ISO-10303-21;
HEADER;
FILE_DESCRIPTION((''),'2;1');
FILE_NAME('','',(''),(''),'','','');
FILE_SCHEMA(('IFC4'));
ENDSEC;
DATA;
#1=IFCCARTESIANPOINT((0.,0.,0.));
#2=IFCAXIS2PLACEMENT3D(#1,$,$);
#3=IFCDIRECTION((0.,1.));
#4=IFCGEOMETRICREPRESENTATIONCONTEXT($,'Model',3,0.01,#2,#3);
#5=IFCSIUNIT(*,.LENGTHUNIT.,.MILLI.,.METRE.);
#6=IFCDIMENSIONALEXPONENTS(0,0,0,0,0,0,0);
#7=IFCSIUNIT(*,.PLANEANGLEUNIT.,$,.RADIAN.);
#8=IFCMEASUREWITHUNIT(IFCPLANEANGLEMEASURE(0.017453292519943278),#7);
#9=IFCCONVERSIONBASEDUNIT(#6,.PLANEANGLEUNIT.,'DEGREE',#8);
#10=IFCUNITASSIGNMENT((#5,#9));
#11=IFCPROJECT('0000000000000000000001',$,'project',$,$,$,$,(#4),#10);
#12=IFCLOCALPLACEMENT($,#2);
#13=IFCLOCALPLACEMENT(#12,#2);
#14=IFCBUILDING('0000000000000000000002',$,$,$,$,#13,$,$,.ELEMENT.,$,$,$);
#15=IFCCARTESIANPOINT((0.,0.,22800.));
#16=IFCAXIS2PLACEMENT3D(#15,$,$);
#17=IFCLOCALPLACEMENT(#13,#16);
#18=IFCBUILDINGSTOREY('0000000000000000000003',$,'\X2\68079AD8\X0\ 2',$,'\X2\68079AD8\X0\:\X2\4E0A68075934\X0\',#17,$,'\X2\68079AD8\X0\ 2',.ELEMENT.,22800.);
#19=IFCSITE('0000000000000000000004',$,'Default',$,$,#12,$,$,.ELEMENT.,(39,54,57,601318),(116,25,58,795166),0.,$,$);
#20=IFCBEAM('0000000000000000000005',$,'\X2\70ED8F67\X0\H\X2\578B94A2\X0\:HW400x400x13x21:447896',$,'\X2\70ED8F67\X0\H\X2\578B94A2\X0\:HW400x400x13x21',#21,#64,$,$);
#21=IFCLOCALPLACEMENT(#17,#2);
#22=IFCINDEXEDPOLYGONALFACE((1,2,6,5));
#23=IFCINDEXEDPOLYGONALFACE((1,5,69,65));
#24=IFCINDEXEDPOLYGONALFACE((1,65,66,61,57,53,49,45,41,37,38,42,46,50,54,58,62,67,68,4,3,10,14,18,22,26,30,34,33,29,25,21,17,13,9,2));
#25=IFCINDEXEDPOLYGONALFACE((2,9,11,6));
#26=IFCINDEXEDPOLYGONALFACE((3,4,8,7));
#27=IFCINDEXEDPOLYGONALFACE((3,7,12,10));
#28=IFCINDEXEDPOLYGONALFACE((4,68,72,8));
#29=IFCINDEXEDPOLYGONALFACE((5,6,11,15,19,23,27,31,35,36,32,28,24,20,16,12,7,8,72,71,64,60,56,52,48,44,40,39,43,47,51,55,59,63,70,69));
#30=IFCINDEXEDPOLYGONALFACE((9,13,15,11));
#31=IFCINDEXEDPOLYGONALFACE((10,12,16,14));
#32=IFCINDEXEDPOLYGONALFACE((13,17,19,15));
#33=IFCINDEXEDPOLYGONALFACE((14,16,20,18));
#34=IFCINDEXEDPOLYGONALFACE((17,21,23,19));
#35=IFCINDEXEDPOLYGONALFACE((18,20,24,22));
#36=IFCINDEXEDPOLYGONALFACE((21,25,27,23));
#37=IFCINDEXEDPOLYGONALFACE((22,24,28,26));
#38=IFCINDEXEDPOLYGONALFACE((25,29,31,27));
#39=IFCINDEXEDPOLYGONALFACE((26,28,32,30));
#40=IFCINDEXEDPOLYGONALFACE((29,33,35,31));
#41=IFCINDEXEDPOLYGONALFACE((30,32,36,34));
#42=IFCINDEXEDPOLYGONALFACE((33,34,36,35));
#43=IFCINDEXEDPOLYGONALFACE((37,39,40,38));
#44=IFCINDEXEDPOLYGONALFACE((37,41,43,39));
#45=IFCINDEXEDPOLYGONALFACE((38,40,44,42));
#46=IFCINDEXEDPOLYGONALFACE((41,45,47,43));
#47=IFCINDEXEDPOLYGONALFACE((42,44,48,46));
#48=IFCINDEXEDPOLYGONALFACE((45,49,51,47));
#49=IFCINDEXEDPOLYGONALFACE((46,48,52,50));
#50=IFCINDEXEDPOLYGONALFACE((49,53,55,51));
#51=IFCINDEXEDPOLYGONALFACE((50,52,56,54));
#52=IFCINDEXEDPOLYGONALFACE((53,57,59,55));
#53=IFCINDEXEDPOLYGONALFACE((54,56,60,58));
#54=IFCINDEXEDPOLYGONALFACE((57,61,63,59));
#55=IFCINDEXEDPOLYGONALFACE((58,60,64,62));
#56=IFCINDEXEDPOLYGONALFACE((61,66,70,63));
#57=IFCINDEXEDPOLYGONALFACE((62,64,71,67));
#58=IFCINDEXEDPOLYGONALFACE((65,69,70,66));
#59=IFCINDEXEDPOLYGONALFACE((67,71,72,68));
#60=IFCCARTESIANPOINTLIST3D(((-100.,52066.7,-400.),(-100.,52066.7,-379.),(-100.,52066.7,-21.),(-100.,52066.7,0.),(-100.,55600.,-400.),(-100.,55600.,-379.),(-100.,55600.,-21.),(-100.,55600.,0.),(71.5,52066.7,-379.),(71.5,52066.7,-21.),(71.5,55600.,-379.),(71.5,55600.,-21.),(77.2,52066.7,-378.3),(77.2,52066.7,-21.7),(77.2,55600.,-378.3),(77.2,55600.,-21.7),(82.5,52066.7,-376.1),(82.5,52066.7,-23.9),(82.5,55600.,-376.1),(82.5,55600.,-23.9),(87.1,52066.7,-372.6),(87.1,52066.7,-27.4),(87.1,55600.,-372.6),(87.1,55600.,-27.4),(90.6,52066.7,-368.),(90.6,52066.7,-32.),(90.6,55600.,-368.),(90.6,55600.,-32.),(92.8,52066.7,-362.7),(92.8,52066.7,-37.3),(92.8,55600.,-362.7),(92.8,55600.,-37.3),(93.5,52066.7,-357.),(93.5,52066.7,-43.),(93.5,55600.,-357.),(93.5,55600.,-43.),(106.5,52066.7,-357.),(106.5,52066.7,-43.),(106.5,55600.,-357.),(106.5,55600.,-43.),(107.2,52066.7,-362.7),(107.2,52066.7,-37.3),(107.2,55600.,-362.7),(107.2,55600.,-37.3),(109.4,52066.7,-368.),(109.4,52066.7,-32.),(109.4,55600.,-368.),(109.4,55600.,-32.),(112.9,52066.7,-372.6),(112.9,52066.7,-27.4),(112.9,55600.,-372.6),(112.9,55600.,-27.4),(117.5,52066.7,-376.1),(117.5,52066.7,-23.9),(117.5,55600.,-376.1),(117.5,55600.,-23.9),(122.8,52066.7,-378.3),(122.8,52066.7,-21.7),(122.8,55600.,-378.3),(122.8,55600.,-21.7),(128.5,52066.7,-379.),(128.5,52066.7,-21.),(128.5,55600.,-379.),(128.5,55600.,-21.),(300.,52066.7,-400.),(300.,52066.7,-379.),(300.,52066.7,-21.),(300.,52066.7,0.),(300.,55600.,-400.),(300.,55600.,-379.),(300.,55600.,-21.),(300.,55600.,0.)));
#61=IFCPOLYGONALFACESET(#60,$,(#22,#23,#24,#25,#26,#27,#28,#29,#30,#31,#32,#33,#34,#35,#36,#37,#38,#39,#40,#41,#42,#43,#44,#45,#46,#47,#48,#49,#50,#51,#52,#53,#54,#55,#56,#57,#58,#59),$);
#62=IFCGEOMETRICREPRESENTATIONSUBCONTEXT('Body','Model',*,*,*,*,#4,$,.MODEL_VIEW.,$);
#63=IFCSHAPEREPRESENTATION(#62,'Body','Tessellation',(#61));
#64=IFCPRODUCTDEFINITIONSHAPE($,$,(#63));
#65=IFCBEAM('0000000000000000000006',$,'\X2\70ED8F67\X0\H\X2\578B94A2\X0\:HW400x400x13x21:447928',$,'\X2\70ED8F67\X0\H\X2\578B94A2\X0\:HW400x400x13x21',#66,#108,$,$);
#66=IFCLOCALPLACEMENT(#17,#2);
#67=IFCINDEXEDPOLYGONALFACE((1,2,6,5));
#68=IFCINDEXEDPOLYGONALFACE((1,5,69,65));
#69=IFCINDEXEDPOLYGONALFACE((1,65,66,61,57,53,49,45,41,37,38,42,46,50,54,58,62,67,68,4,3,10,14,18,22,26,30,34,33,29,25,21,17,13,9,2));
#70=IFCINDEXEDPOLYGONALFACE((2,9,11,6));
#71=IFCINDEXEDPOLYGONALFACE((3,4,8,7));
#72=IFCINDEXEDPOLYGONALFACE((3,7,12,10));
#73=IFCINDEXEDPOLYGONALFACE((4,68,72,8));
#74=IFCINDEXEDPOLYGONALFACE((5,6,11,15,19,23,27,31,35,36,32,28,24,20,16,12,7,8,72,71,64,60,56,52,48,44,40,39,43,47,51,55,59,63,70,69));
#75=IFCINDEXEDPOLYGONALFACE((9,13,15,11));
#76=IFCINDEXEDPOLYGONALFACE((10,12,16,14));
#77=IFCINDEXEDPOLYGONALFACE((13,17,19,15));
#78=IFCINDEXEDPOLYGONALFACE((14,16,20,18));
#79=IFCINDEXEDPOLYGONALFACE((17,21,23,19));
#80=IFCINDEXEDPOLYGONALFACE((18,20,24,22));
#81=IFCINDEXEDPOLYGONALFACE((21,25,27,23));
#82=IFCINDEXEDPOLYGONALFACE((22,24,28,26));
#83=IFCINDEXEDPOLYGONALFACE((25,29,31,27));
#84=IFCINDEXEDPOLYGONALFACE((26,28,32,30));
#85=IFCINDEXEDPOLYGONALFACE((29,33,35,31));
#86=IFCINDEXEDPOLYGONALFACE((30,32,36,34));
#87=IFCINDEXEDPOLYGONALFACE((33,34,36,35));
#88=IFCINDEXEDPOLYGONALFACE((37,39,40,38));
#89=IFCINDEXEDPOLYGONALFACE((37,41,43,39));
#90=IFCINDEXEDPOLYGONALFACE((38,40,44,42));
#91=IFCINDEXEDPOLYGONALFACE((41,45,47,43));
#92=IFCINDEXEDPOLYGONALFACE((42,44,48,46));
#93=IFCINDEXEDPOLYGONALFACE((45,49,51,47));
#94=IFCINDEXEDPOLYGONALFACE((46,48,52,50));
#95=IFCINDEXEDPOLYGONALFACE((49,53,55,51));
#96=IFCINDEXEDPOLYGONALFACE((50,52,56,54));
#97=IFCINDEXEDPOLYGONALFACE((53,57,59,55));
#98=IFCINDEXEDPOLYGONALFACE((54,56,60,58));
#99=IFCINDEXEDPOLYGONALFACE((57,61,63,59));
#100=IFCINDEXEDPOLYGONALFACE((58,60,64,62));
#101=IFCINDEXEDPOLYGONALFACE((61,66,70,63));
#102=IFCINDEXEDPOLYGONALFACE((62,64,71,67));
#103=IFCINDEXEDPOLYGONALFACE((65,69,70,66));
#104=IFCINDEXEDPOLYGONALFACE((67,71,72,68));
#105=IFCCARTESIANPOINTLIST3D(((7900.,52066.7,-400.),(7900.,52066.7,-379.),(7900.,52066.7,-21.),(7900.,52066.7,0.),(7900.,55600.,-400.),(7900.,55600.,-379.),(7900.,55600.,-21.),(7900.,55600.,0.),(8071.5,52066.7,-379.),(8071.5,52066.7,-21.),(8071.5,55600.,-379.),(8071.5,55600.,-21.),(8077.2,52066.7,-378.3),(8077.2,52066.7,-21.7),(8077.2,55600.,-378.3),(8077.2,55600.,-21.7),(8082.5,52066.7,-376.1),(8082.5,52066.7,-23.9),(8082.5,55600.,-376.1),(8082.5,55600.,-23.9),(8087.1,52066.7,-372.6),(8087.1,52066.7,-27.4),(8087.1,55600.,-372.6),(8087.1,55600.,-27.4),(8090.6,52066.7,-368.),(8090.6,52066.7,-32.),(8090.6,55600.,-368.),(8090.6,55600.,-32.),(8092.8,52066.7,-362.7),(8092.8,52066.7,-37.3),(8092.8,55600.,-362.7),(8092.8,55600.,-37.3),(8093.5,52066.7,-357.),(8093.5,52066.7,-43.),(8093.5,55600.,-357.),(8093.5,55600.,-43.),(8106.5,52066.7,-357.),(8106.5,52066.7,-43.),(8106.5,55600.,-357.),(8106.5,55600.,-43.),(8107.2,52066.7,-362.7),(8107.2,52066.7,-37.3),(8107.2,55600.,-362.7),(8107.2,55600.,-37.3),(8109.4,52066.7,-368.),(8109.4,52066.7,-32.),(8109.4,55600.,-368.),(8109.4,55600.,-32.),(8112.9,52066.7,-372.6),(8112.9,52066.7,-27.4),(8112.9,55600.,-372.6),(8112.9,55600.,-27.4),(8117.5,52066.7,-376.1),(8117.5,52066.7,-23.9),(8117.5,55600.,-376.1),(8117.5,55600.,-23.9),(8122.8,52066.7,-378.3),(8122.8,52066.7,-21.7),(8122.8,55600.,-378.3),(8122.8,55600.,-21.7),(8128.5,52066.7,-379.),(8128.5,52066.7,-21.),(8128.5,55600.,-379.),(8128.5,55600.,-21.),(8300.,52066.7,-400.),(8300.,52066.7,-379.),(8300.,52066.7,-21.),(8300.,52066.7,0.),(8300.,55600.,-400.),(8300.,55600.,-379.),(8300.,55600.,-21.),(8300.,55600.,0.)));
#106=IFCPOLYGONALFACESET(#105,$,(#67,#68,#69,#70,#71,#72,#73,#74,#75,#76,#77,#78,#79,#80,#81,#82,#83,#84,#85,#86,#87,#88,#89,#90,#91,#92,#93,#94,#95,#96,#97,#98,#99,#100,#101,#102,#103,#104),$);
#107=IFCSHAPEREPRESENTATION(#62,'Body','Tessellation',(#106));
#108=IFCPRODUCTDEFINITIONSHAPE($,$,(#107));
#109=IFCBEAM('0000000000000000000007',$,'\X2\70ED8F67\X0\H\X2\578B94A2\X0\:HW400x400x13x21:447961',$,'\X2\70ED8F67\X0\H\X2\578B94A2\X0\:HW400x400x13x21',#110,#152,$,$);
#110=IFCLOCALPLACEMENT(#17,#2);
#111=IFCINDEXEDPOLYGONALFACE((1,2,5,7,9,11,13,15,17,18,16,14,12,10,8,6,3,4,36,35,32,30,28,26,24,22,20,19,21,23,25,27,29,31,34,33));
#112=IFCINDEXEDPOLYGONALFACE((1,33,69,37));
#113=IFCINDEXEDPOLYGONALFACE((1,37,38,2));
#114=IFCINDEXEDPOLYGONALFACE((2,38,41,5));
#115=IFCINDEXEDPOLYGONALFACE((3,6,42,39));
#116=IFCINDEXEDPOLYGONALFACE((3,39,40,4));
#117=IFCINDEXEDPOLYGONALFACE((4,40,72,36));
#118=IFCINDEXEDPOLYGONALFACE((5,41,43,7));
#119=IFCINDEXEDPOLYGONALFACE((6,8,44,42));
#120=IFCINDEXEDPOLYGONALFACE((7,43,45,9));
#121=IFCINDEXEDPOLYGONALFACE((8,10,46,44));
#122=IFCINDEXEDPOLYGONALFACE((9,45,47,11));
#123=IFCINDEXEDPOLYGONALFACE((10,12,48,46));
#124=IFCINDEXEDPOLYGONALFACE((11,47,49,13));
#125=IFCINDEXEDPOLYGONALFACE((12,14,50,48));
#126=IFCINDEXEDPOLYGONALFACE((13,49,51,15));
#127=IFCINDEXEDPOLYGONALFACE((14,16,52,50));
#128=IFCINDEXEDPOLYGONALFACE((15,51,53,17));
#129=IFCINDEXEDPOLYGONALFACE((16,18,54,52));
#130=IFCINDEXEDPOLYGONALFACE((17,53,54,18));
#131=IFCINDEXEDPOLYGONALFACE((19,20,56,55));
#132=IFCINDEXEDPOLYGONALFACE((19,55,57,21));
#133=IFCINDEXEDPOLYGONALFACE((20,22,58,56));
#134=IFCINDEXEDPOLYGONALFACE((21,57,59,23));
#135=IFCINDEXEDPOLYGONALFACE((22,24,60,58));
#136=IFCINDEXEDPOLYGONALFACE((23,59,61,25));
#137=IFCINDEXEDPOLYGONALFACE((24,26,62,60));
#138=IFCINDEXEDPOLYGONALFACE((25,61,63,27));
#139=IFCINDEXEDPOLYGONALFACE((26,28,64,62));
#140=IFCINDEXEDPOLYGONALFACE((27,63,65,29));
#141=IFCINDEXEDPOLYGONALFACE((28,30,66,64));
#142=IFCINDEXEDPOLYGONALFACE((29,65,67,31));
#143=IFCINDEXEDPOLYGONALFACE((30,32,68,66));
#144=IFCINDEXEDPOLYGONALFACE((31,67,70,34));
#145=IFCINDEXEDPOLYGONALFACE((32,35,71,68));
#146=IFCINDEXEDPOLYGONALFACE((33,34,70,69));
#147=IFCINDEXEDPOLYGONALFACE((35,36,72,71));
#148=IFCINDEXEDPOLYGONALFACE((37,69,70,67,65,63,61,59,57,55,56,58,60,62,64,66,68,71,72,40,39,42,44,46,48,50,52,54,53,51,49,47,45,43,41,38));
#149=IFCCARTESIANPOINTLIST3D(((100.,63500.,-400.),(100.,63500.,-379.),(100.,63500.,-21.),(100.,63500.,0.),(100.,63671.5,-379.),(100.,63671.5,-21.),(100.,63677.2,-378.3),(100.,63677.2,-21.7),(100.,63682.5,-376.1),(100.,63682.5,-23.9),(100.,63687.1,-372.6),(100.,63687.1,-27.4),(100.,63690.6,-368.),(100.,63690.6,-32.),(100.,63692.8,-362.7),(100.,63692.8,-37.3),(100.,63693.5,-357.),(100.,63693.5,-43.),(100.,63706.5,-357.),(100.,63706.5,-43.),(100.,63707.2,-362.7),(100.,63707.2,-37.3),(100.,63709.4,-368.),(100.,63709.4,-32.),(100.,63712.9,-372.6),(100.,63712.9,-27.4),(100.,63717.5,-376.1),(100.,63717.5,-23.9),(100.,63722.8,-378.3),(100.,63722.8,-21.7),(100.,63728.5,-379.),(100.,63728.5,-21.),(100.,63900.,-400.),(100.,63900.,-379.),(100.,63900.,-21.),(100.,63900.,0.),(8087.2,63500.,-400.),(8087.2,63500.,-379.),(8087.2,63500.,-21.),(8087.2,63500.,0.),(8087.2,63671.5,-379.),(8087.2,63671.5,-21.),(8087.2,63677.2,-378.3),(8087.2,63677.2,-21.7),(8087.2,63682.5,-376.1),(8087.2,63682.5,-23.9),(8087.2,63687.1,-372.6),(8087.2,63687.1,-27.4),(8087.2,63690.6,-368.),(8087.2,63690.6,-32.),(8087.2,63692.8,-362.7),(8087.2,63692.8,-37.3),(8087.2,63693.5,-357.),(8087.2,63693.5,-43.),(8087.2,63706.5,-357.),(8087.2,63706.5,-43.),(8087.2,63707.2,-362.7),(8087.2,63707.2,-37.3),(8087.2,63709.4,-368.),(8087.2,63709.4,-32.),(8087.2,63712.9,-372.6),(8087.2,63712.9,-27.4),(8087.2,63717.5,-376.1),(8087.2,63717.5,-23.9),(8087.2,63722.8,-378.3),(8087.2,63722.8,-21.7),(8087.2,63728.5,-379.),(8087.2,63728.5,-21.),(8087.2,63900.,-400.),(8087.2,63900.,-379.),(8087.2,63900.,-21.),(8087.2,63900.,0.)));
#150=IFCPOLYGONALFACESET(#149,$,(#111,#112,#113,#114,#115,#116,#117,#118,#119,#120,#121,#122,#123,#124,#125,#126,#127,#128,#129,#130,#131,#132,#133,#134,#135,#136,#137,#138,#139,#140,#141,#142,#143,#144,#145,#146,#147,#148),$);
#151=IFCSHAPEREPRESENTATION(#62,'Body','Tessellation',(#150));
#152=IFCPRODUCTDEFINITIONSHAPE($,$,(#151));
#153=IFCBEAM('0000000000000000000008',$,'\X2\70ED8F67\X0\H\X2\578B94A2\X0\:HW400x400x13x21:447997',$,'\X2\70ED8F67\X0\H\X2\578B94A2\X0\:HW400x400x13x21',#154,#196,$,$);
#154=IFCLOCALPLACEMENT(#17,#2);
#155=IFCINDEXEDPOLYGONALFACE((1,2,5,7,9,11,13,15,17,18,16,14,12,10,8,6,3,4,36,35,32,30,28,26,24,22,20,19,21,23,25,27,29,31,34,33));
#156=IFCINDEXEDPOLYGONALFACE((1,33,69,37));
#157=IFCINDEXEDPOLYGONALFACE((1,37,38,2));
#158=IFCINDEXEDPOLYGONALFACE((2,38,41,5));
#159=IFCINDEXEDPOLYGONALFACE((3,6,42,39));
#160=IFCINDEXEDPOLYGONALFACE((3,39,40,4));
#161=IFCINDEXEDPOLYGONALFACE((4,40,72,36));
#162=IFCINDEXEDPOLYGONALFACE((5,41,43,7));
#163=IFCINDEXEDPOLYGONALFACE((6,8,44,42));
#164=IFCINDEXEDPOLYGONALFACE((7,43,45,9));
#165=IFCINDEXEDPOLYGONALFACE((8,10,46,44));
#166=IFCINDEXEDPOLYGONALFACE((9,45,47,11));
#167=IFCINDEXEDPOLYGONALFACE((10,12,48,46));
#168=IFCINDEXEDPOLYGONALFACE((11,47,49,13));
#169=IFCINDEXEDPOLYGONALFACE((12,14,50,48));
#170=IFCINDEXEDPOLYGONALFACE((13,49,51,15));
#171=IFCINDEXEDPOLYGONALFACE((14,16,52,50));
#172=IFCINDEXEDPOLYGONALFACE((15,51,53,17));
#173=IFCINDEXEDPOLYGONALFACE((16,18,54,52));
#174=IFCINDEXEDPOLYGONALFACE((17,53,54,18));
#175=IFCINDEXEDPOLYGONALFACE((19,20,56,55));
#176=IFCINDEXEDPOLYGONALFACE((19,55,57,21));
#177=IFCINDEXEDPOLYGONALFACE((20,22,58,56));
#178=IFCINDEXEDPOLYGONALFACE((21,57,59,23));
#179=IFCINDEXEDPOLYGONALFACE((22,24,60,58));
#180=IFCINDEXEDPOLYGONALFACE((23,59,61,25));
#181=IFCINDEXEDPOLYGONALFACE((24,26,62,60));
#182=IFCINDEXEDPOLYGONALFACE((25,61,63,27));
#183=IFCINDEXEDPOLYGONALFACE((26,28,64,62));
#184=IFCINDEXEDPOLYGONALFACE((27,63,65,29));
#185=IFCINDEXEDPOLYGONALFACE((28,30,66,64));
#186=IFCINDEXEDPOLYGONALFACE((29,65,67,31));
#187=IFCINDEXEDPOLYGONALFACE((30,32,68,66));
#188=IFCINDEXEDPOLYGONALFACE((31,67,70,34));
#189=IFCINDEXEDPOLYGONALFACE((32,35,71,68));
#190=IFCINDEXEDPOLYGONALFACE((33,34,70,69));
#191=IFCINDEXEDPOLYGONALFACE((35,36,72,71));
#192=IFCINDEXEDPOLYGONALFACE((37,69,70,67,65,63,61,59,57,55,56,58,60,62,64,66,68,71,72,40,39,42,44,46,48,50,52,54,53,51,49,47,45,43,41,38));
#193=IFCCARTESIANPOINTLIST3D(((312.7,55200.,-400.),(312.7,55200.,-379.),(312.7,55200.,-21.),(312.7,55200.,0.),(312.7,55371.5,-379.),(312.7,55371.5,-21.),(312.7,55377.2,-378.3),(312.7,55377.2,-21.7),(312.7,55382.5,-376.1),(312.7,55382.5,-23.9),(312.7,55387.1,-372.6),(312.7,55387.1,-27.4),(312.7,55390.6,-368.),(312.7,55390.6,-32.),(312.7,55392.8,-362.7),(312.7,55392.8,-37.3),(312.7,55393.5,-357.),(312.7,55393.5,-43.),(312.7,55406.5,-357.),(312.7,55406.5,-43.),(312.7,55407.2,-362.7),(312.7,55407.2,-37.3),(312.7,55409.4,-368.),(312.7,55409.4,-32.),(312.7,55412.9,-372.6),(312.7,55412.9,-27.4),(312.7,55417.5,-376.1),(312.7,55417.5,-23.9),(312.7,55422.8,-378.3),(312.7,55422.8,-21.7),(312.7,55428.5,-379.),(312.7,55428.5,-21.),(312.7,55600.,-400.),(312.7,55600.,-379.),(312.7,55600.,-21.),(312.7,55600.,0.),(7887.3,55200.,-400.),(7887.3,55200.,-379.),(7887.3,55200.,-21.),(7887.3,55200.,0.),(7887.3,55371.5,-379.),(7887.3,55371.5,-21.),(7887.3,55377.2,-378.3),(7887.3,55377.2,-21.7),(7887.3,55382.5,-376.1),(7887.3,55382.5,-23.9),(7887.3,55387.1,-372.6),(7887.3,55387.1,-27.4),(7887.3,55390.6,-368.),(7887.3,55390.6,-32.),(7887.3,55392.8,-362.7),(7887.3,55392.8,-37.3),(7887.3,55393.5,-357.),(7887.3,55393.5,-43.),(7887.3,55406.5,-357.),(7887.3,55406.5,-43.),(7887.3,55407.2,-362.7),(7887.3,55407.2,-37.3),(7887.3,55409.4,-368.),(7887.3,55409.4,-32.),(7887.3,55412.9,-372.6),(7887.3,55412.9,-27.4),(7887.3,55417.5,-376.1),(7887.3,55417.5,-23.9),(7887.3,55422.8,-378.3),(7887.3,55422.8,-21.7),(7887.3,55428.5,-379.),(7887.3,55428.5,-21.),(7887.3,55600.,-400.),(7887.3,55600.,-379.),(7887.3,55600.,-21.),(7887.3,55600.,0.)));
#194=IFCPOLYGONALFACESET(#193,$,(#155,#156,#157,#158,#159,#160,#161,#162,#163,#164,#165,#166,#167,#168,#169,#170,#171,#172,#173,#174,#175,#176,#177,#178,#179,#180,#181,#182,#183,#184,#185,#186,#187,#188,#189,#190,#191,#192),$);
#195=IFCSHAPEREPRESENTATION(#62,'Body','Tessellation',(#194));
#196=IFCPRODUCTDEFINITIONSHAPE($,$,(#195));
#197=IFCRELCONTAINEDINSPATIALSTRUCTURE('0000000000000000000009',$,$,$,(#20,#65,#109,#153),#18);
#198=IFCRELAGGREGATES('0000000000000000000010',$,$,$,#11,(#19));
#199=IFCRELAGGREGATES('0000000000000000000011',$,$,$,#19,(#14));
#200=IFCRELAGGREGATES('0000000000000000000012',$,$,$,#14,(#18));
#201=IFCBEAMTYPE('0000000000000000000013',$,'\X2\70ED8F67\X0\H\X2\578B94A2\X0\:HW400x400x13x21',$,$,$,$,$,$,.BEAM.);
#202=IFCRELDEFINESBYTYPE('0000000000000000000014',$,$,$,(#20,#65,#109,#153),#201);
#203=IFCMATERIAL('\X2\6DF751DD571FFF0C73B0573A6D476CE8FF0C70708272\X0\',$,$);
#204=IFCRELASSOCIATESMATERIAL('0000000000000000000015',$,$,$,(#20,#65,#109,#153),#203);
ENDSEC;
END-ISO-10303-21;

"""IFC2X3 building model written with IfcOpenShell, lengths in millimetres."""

from ifc_helpers import new_model, entity, si_unit, converted_unit, direction, frame, frame_2d, origin, place, context, subcontext, project, spatial, i_section, extrude, material, type_object, element, save


model = new_model("IFC2X3")

# Units and contexts
model_context = context("Model", 3, precision=0.01, world=origin(), true_north=direction((0.0, 1.0)))
body_context = subcontext(model_context, "Body", "Model", "MODEL_VIEW")
ifc_project = project(units=[si_unit("LENGTHUNIT", "METRE", prefix="MILLI"), converted_unit("PLANEANGLEUNIT", "DEGREE", entity("IfcPlaneAngleMeasure", 0.017453292519943278), si_unit("PLANEANGLEUNIT", "RADIAN"), dimensions=[0, 0, 0, 0, 0, 0, 0])], contexts=[model_context])

# Site, building, storey
site_placement = place(None, origin())
site = spatial("IfcSite", under=ifc_project, at=site_placement, Name="Default", CompositionType="ELEMENT", RefLatitude=(39, 54, 57, 601318), RefLongitude=(116, 25, 58, 795166), RefElevation=0.0)
building_placement = place(site_placement, origin())
building = spatial("IfcBuilding", under=site, at=building_placement, CompositionType="ELEMENT")
storey_placement = place(building_placement, frame((0.0, 0.0, 22800.0)))
storey = spatial("IfcBuildingStorey", under=building, at=storey_placement, Name="标高 2", ObjectType="标高:上标头", LongName="标高 2", CompositionType="ELEMENT", Elevation=22800.0)

# Beams
ifc_material = material(Name="混凝土，现场浇注，灰色")
beam_type = type_object("IfcBeamType", Name="热轧H型钢:HW400x400x13x21", PredefinedType="BEAM")
beam_1_placement = place(storey_placement, frame((100.0, 55400.0, 0.0), z_axis=(0.0, 0.0, 1.0), x_axis=(0.0, -1.0, 0.0)))
element("IfcBeam", 1, at=beam_1_placement, inside=storey, type_object=beam_type, material=ifc_material, Name="热轧H型钢:HW400x400x13x21:447896", ObjectType="热轧H型钢:HW400x400x13x21", context=body_context, shape_type="SweptSolid", body=[
    extrude(i_section(OverallWidth=400.0, OverallDepth=400.0, WebThickness=13.0, FlangeThickness=21.0, FilletRadius=22.0, at=frame_2d((0.0, 0.0), x_axis=(0.0, 1.0))), frame((-200.0, 0.0, -200.0), z_axis=(1.0, 0.0, 0.0), x_axis=(0.0, 0.0, -1.0)), (0.0, 0.0, 1.0), 3533.3),
])
beam_2_placement = place(storey_placement, frame((8100.0, 55400.0, 0.0), z_axis=(0.0, 0.0, 1.0), x_axis=(0.0, -1.0, 0.0)))
element("IfcBeam", 2, at=beam_2_placement, inside=storey, type_object=beam_type, material=ifc_material, Name="热轧H型钢:HW400x400x13x21:447928", ObjectType="热轧H型钢:HW400x400x13x21", context=body_context, shape_type="SweptSolid", body=[
    extrude(i_section(OverallWidth=400.0, OverallDepth=400.0, WebThickness=13.0, FlangeThickness=21.0, FilletRadius=22.0, at=frame_2d((0.0, 0.0), x_axis=(0.0, 1.0))), frame((-200.0, 0.0, -200.0), z_axis=(1.0, 0.0, 0.0), x_axis=(0.0, 0.0, -1.0)), (0.0, 0.0, 1.0), 3533.3),
])
beam_3_placement = place(storey_placement, frame((100.0, 63700.0, 0.0)))
element("IfcBeam", 3, at=beam_3_placement, inside=storey, type_object=beam_type, material=ifc_material, Name="热轧H型钢:HW400x400x13x21:447961", ObjectType="热轧H型钢:HW400x400x13x21", context=body_context, shape_type="SweptSolid", body=[
    extrude(i_section(OverallWidth=400.0, OverallDepth=400.0, WebThickness=13.0, FlangeThickness=21.0, FilletRadius=22.0, at=frame_2d((0.0, 0.0), x_axis=(0.0, 1.0))), frame((0.0, 0.0, -200.0), z_axis=(1.0, 0.0, 0.0), x_axis=(0.0, 0.0, -1.0)), (0.0, 0.0, 1.0), 7987.2),
])
beam_4_placement = place(storey_placement, frame((8100.0, 55400.0, 0.0), z_axis=(0.0, 0.0, 1.0), x_axis=(-1.0, 0.0, 0.0)))
element("IfcBeam", 4, at=beam_4_placement, inside=storey, type_object=beam_type, material=ifc_material, Name="热轧H型钢:HW400x400x13x21:447997", ObjectType="热轧H型钢:HW400x400x13x21", context=body_context, shape_type="SweptSolid", body=[
    extrude(i_section(OverallWidth=400.0, OverallDepth=400.0, WebThickness=13.0, FlangeThickness=21.0, FilletRadius=22.0, at=frame_2d((0.0, 0.0), x_axis=(0.0, 1.0))), frame((212.7, 0.0, -200.0), z_axis=(1.0, 0.0, 0.0), x_axis=(0.0, 0.0, -1.0)), (0.0, 0.0, 1.0), 7574.6),
])

save(model, "model.ifc")
